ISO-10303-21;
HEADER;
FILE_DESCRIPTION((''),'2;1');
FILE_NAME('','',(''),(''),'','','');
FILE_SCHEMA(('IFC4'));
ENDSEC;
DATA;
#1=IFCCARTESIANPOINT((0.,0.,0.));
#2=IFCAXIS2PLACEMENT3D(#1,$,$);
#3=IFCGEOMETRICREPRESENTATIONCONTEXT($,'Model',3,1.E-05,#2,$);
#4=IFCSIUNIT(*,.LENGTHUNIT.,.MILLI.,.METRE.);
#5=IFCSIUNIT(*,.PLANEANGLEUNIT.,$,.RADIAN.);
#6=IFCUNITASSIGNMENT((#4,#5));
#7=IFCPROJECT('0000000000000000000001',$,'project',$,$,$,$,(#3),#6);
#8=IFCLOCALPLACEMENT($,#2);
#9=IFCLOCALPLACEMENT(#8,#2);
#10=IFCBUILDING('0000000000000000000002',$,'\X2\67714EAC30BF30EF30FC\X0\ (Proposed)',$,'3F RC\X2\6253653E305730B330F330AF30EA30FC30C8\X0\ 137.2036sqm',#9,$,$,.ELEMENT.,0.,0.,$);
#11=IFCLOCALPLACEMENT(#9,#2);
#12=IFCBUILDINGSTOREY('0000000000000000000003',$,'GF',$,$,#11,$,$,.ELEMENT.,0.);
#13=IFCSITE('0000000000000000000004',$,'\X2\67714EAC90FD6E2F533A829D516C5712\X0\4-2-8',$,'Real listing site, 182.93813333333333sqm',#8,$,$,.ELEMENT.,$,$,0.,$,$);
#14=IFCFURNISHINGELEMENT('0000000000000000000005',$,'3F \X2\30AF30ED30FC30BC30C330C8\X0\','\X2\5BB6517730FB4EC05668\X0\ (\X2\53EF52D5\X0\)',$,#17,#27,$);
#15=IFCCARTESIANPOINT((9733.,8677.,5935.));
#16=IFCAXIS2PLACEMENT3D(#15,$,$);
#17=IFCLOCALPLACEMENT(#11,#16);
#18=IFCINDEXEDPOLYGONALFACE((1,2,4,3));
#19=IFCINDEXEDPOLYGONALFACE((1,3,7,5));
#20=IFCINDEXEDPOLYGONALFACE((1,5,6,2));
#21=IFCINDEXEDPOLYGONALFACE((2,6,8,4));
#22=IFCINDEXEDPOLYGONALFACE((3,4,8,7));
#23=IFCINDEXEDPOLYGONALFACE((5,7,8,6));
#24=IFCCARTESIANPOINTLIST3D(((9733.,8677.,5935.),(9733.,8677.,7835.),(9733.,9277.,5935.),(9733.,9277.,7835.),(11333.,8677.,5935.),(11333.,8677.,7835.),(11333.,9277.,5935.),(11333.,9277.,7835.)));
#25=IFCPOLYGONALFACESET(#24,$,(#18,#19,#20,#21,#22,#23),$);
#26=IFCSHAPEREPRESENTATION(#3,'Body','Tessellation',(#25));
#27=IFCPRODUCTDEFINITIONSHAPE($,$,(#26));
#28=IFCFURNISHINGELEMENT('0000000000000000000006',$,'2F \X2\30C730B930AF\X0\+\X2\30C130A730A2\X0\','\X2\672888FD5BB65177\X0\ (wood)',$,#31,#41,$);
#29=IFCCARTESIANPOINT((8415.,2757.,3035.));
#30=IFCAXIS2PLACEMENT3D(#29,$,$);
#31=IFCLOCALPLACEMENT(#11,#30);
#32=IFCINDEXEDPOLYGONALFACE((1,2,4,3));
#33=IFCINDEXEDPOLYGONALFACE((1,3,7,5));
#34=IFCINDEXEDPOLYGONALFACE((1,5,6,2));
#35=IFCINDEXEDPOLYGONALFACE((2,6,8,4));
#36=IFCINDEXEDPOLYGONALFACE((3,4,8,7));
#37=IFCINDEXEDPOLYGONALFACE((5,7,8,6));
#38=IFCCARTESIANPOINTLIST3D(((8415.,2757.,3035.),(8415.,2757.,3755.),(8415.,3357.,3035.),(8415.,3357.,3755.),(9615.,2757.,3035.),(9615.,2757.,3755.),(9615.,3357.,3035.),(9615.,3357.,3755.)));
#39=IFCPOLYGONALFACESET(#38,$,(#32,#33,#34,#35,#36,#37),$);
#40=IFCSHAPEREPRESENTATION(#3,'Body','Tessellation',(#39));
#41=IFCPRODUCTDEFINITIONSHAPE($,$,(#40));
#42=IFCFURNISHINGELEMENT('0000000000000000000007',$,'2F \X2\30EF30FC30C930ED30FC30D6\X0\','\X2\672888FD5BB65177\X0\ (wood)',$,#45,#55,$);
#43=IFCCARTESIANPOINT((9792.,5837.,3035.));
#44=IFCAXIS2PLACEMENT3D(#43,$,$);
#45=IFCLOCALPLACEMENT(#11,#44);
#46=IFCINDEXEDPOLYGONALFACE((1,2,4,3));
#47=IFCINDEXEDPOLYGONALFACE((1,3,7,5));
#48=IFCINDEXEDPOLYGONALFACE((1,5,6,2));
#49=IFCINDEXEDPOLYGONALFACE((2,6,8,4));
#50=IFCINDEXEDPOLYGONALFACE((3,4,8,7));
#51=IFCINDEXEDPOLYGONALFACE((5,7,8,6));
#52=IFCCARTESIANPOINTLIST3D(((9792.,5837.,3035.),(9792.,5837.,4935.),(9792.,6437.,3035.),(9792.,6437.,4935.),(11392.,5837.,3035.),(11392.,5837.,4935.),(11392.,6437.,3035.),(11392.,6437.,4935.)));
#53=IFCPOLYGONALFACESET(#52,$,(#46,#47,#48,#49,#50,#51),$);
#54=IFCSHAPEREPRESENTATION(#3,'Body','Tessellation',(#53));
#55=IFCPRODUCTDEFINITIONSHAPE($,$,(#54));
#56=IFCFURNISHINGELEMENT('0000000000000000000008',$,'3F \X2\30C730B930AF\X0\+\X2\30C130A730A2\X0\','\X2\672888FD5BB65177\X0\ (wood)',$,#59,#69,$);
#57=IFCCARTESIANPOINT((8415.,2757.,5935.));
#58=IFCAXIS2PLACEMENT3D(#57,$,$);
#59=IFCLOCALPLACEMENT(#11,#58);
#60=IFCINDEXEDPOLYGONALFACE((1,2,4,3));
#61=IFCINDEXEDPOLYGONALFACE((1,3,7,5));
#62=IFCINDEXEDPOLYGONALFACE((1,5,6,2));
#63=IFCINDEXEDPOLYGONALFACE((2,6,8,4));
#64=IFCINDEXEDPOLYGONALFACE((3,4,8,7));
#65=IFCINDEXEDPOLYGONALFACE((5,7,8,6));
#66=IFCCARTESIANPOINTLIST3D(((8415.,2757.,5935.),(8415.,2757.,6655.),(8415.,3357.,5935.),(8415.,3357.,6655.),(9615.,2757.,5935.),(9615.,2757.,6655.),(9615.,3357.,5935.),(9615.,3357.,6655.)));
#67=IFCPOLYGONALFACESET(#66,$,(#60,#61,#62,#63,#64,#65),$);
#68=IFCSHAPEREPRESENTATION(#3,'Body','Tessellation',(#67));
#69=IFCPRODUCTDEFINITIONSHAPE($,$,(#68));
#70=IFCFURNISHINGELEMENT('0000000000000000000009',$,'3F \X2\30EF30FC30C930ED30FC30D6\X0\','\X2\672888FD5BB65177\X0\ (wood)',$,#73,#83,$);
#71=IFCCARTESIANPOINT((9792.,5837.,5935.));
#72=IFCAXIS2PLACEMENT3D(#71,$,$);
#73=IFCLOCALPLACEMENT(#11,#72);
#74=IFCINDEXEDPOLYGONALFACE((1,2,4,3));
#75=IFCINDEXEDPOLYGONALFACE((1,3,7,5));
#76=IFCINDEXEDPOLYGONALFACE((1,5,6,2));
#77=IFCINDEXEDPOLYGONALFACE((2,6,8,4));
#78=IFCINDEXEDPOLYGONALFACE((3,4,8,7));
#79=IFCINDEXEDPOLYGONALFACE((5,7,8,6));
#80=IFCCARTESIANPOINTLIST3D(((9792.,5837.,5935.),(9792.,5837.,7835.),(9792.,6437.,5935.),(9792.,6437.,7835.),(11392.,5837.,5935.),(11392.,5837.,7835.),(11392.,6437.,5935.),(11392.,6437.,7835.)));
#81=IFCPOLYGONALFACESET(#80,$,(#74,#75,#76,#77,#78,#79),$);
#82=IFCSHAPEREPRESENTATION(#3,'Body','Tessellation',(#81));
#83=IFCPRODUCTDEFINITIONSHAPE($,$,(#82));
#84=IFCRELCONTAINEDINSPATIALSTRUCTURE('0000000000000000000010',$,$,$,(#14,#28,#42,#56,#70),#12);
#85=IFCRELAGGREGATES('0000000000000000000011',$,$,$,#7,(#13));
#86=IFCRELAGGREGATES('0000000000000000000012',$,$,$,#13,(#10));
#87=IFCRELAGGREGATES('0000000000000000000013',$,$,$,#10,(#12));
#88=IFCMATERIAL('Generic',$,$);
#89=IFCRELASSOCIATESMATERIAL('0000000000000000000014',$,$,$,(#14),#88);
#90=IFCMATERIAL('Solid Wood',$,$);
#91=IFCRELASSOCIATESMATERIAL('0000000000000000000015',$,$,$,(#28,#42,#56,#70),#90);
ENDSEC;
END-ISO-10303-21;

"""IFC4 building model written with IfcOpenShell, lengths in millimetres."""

from ifc_helpers import new_model, si_unit, frame, frame_2d, origin, place, context, project, spatial, rectangle, extrude, material, element, save


model = new_model("IFC4")

# Units and contexts
model_context = context("Model", 3, precision=1e-05, world=origin())
ifc_project = project(units=[si_unit("LENGTHUNIT", "METRE", prefix="MILLI"), si_unit("PLANEANGLEUNIT", "RADIAN")], contexts=[model_context])

# Site, building, storey
site_placement = place(None, origin())
site = spatial("IfcSite", under=ifc_project, at=site_placement, Name="東京都港区芝公園4-2-8", ObjectType="Real listing site, 182.93813333333333sqm", CompositionType="ELEMENT", RefElevation=0.0)
building_placement = place(site_placement, origin())
building = spatial("IfcBuilding", under=site, at=building_placement, Name="東京タワー (Proposed)", ObjectType="3F RC打放しコンクリート 137.2036sqm", CompositionType="ELEMENT", ElevationOfRefHeight=0.0, ElevationOfTerrain=0.0)
storey_placement = place(building_placement, origin())
storey = spatial("IfcBuildingStorey", under=building, at=storey_placement, Name="GF", CompositionType="ELEMENT", Elevation=0.0)

# Shared definitions
ifc_material_1 = material(Name="Solid Wood")

# Furnishing elements
ifc_material_2 = material(Name="Generic")
furnishing_1_placement = place(storey_placement, frame((9733.0, 8677.0, 5935.0)))
element("IfcFurnishingElement", 1, at=furnishing_1_placement, inside=storey, material=ifc_material_2, Name="3F クローゼット", Description="家具・什器 (可動)", context=model_context, shape_type="SweptSolid", body=[
    extrude(rectangle(XDim=1600.0, YDim=600.0, at=frame_2d((800.0, 300.0))), frame((9733.0, 8677.0, 5935.0)), (0.0, 0.0, 1.0), 1900.0),
])
furnishing_2_placement = place(storey_placement, frame((8415.0, 2757.0, 3035.0)))
element("IfcFurnishingElement", 2, at=furnishing_2_placement, inside=storey, material=ifc_material_1, Name="2F デスク+チェア", Description="木製家具 (wood)", context=model_context, shape_type="SweptSolid", body=[
    extrude(rectangle(XDim=1200.0, YDim=600.0, at=frame_2d((600.0, 300.0))), frame((8415.0, 2757.0, 3035.0)), (0.0, 0.0, 1.0), 720.0),
])
furnishing_3_placement = place(storey_placement, frame((9792.0, 5837.0, 3035.0)))
element("IfcFurnishingElement", 3, at=furnishing_3_placement, inside=storey, material=ifc_material_1, Name="2F ワードローブ", Description="木製家具 (wood)", context=model_context, shape_type="SweptSolid", body=[
    extrude(rectangle(XDim=1600.0, YDim=600.0, at=frame_2d((800.0, 300.0))), frame((9792.0, 5837.0, 3035.0)), (0.0, 0.0, 1.0), 1900.0),
])
furnishing_4_placement = place(storey_placement, frame((8415.0, 2757.0, 5935.0)))
element("IfcFurnishingElement", 4, at=furnishing_4_placement, inside=storey, material=ifc_material_1, Name="3F デスク+チェア", Description="木製家具 (wood)", context=model_context, shape_type="SweptSolid", body=[
    extrude(rectangle(XDim=1200.0, YDim=600.0, at=frame_2d((600.0, 300.0))), frame((8415.0, 2757.0, 5935.0)), (0.0, 0.0, 1.0), 720.0),
])
furnishing_5_placement = place(storey_placement, frame((9792.0, 5837.0, 5935.0)))
element("IfcFurnishingElement", 5, at=furnishing_5_placement, inside=storey, material=ifc_material_1, Name="3F ワードローブ", Description="木製家具 (wood)", context=model_context, shape_type="SweptSolid", body=[
    extrude(rectangle(XDim=1600.0, YDim=600.0, at=frame_2d((800.0, 300.0))), frame((9792.0, 5837.0, 5935.0)), (0.0, 0.0, 1.0), 1900.0),
])

save(model, "model.ifc")
